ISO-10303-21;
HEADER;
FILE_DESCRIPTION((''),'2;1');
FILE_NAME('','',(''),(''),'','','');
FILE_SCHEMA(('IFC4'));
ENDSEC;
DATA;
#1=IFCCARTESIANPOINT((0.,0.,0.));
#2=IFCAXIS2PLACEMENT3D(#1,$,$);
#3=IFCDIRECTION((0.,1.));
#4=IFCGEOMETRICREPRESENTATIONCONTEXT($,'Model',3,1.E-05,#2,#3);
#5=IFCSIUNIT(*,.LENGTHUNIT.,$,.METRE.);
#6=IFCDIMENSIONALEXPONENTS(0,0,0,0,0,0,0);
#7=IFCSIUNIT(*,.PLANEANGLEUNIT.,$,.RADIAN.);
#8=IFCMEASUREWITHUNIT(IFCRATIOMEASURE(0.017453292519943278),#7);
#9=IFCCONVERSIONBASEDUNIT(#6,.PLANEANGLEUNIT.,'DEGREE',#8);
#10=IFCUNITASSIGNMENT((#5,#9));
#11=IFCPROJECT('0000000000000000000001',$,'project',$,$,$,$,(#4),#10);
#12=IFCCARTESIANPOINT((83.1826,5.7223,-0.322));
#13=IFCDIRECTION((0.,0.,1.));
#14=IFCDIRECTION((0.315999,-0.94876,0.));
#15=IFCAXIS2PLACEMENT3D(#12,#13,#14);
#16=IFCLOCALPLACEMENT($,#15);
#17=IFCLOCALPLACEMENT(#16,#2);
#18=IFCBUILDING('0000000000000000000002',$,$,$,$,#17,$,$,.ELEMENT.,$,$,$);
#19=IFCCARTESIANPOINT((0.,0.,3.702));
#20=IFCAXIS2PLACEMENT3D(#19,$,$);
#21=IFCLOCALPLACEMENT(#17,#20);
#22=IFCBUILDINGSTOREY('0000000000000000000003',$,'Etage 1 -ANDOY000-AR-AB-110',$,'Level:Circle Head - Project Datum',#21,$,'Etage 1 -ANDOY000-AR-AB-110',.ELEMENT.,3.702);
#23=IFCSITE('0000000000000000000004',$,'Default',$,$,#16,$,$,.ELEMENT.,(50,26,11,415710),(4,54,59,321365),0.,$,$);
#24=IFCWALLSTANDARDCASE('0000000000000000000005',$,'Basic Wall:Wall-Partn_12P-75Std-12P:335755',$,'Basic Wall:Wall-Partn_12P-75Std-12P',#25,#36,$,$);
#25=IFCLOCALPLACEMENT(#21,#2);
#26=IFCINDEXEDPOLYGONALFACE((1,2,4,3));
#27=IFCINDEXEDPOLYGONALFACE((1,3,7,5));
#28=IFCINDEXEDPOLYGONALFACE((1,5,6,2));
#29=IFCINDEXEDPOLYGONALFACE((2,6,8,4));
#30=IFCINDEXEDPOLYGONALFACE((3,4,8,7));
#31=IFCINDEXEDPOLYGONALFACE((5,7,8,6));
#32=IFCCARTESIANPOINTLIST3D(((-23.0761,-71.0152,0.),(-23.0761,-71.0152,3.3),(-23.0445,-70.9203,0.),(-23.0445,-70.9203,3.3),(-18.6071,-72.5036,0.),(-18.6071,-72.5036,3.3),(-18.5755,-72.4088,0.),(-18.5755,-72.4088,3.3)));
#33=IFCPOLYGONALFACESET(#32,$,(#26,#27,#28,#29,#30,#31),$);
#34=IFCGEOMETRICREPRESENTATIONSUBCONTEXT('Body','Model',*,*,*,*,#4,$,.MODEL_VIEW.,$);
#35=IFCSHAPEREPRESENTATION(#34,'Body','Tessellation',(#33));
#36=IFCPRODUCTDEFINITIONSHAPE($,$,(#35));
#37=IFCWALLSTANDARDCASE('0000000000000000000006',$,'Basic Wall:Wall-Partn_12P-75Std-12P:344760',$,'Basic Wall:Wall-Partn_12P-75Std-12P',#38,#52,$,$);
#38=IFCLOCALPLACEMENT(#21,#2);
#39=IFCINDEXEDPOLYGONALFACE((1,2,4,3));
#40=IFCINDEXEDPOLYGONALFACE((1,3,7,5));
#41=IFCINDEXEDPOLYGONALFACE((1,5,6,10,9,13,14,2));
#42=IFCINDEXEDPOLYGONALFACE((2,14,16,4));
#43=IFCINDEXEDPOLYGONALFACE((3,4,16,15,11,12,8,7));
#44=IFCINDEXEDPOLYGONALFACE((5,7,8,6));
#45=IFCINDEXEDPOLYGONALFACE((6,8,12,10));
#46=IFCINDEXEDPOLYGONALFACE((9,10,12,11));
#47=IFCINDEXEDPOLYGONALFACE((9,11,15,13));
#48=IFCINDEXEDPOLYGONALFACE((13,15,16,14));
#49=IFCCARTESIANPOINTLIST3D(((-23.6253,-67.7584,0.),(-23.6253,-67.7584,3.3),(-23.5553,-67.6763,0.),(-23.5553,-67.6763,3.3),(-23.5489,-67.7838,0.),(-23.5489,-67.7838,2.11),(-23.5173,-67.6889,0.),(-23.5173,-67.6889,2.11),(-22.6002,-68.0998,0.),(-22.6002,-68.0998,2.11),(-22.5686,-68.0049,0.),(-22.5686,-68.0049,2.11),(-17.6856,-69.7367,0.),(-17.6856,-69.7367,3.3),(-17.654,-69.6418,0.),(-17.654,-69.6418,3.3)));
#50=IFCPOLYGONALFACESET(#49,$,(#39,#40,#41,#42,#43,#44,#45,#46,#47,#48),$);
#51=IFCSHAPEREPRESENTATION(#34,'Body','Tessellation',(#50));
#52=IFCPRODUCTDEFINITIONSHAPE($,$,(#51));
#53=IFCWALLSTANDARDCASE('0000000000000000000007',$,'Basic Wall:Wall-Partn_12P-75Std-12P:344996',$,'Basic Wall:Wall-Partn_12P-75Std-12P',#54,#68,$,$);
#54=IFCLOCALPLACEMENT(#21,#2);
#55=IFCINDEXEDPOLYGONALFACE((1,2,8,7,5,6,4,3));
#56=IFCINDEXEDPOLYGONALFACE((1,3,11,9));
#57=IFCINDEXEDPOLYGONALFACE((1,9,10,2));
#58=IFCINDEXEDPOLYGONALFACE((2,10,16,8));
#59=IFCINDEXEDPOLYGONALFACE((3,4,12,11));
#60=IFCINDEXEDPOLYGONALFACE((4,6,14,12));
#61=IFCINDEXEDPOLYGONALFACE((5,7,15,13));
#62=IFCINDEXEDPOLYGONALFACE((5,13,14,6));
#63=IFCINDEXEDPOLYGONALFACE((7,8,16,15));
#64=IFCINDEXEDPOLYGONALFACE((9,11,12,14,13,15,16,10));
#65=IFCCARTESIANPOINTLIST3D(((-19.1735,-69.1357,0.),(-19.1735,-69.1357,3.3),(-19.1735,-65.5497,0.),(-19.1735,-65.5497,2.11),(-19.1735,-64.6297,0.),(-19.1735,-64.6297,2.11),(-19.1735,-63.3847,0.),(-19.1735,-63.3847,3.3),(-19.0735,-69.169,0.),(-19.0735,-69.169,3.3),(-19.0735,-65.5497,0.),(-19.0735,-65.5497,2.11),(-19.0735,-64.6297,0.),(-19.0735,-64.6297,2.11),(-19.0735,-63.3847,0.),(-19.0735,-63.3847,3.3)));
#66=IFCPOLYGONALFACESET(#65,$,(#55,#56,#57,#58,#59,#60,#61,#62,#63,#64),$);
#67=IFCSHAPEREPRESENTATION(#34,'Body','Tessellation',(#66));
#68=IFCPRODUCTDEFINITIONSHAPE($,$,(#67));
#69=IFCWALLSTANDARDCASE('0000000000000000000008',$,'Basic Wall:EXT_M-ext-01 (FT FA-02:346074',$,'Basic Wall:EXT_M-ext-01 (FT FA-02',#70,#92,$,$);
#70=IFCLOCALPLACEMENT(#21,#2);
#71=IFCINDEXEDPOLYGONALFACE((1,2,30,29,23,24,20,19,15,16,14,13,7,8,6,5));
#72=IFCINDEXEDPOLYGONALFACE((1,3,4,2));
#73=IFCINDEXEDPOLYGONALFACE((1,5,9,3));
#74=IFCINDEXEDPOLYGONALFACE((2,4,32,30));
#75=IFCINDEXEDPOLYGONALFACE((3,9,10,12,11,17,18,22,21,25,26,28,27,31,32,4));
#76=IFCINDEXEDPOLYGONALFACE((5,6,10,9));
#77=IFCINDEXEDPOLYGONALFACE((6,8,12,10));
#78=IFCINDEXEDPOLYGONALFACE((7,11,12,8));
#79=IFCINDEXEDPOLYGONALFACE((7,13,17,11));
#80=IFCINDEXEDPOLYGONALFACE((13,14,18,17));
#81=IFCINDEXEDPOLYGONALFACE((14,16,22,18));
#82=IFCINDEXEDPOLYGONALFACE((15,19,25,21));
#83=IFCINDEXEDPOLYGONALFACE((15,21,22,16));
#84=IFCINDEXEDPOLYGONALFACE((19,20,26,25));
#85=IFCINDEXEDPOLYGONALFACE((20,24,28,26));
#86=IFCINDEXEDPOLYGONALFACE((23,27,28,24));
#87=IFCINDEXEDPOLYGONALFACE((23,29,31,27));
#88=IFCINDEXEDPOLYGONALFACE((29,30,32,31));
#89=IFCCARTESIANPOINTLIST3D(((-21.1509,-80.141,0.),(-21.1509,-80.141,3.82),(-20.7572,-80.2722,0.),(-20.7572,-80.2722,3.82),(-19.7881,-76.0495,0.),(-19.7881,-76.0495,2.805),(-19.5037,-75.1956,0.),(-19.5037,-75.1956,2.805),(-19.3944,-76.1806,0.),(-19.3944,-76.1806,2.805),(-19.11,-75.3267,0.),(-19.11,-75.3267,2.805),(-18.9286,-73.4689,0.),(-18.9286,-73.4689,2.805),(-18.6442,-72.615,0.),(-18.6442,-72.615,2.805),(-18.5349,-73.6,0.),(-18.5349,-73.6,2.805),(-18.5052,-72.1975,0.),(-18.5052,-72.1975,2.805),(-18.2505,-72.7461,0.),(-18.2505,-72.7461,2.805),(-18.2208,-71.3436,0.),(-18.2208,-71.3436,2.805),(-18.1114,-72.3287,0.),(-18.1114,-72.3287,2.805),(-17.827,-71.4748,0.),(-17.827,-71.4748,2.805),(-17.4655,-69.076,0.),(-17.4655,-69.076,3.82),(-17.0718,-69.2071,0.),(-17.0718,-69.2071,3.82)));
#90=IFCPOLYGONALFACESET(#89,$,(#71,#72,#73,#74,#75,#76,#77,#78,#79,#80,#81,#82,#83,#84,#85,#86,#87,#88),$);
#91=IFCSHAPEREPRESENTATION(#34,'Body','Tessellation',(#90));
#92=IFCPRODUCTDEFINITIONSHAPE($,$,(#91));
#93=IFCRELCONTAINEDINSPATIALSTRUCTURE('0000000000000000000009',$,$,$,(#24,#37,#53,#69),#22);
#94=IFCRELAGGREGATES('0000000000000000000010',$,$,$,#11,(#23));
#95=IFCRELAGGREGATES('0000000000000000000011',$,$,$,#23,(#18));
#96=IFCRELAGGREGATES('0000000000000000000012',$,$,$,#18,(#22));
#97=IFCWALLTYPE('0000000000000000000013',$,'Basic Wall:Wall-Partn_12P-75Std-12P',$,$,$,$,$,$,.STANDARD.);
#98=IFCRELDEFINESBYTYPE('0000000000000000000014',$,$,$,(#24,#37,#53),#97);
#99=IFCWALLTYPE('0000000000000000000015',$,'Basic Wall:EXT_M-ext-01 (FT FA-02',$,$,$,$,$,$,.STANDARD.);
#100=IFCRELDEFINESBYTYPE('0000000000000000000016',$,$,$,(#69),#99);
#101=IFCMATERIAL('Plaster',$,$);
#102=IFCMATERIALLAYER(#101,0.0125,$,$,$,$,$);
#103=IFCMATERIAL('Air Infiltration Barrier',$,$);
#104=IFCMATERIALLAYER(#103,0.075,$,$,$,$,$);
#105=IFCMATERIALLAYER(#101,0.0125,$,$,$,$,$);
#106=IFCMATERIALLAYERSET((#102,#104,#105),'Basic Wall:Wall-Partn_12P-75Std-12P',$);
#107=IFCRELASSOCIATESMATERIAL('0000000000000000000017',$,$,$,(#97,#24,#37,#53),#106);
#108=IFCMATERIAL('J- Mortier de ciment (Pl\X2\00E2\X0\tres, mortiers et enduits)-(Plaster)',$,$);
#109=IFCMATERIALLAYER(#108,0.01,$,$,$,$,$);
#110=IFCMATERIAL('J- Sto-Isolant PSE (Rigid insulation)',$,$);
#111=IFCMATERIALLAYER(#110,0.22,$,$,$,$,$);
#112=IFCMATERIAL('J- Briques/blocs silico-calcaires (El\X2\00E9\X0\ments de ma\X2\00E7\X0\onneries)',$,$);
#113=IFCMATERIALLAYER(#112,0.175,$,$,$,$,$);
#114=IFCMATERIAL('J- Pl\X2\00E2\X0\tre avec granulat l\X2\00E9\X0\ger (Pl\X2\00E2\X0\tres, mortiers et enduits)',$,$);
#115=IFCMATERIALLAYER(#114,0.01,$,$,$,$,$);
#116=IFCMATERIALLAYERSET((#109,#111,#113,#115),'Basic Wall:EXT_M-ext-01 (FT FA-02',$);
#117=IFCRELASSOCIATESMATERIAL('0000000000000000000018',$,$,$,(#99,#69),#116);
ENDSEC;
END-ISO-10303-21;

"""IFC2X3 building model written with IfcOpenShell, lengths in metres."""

from ifc_helpers import new_model, entity, si_unit, converted_unit, direction, frame, frame_2d, origin, place, context, subcontext, project, spatial, polyline, rectangle, outline, extrude, material, layer, layer_set, layer_usage, type_object, element, save


model = new_model("IFC2X3")

# Units and contexts
model_context = context("Model", 3, precision=1e-05, world=origin(), true_north=direction((0.0, 1.0)))
body_context = subcontext(model_context, "Body", "Model", "MODEL_VIEW")
ifc_project = project(units=[si_unit("LENGTHUNIT", "METRE"), converted_unit("PLANEANGLEUNIT", "DEGREE", entity("IfcRatioMeasure", 0.017453292519943278), si_unit("PLANEANGLEUNIT", "RADIAN"), dimensions=[0, 0, 0, 0, 0, 0, 0])], contexts=[model_context])

# Site, building, storey
site_placement = place(None, frame((83.1826, 5.7223, -0.322), z_axis=(0.0, 0.0, 1.0), x_axis=(0.315999, -0.94876, 0.0)))
site = spatial("IfcSite", under=ifc_project, at=site_placement, Name="Default", CompositionType="ELEMENT", RefLatitude=(50, 26, 11, 415710), RefLongitude=(4, 54, 59, 321365), RefElevation=0.0)
building_placement = place(site_placement, origin())
building = spatial("IfcBuilding", under=site, at=building_placement, CompositionType="ELEMENT")
storey_placement = place(building_placement, frame((0.0, 0.0, 3.702)))
storey = spatial("IfcBuildingStorey", under=building, at=storey_placement, Name="Etage 1 -ANDOY000-AR-AB-110", ObjectType="Level:Circle Head - Project Datum", LongName="Etage 1 -ANDOY000-AR-AB-110", CompositionType="ELEMENT", Elevation=3.702)

# Wall
ifc_material_1 = material(Name="Plaster")
ifc_layer_1 = layer(ifc_material_1, 0.0125)
ifc_material_2 = material(Name="Air Infiltration Barrier")
ifc_layer_2 = layer(ifc_material_2, 0.075)
ifc_layer_3 = layer(ifc_material_1, 0.0125)
ifc_layer_set_1 = layer_set([ifc_layer_1, ifc_layer_2, ifc_layer_3], Name="Basic Wall:Wall-Partn_12P-75Std-12P")
ifc_layer_usage_1 = layer_usage(ifc_layer_set_1, "AXIS2", "NEGATIVE", 0.05)
wall_type_1 = type_object("IfcWallType", Name="Basic Wall:Wall-Partn_12P-75Std-12P", PredefinedType="STANDARD", material=ifc_layer_set_1)
wall_1_placement = place(storey_placement, frame((-18.5913, -72.4562, 0.0), z_axis=(0.0, 0.0, 1.0), x_axis=(-0.948759, 0.316, 0.0)))
element("IfcWallStandardCase", 1, at=wall_1_placement, inside=storey, type_object=wall_type_1, material=ifc_layer_usage_1, Name="Basic Wall:Wall-Partn_12P-75Std-12P:335755", ObjectType="Basic Wall:Wall-Partn_12P-75Std-12P", context=body_context, shape_type="SweptSolid", body=[
    extrude(rectangle(XDim=4.7103, YDim=0.1, at=frame_2d((2.3552, 0.0), x_axis=(-1.0, 0.0))), origin(), (0.0, 0.0, 1.0), 3.3),
])

# Walls, openings
wall_2_placement = place(storey_placement, frame((-17.6698, -69.6893, 0.0), z_axis=(0.0, 0.0, 1.0), x_axis=(-0.948759, 0.316, 0.0)))
wall_2 = element("IfcWallStandardCase", 2, at=wall_2_placement, inside=storey, type_object=wall_type_1, material=ifc_layer_usage_1, Name="Basic Wall:Wall-Partn_12P-75Std-12P:344760", ObjectType="Basic Wall:Wall-Partn_12P-75Std-12P", context=body_context, shape_type="SweptSolid", body=[
    extrude(outline(polyline([(0.0, -0.05), (1.4962, -0.05), (1.6016, -0.05), (6.2201, -0.05), (6.2605, 0.05), (0.0, 0.05), (0.0, -0.05)])), origin(), (0.0, 0.0, 1.0), 3.3),
])
opening_1_placement = place(wall_2_placement, frame((6.18, 0.05, 0.0)))
element("IfcOpeningElement", 3, at=opening_1_placement, cuts=wall_2, ObjectType="Opening", context=body_context, shape_type="SweptSolid", body=[
    extrude(rectangle(XDim=2.11, YDim=1.0, at=frame_2d((1.055, 0.5), x_axis=(1.0, 0.0))), frame((0.0, 0.0, 0.0), z_axis=(0.0, -1.0, 0.0), x_axis=(0.0, 0.0, 1.0)), (0.0, 0.0, 1.0), 0.1),
])
wall_3_placement = place(storey_placement, frame((-19.1235, -69.169, 0.0), z_axis=(0.0, 0.0, 1.0), x_axis=(0.0, 1.0, 0.0)))
wall_3 = element("IfcWallStandardCase", 4, at=wall_3_placement, inside=storey, type_object=wall_type_1, material=ifc_layer_usage_1, Name="Basic Wall:Wall-Partn_12P-75Std-12P:344996", ObjectType="Basic Wall:Wall-Partn_12P-75Std-12P", context=body_context, shape_type="SweptSolid", body=[
    extrude(outline(polyline([(0.0, -0.05), (4.7193, -0.05), (4.8193, -0.05), (5.7843, -0.05), (5.7843, 0.05), (0.0333, 0.05), (0.0, -0.05)])), origin(), (0.0, 0.0, 1.0), 3.3),
])
opening_2_placement = place(wall_3_placement, frame((4.5393, 0.05, 0.0)))
element("IfcOpeningElement", 5, at=opening_2_placement, cuts=wall_3, ObjectType="Opening", context=body_context, shape_type="SweptSolid", body=[
    extrude(rectangle(XDim=2.11, YDim=0.92, at=frame_2d((1.055, 0.46), x_axis=(1.0, 0.0))), frame((0.0, 0.0, 0.0), z_axis=(0.0, -1.0, 0.0), x_axis=(0.0, 0.0, 1.0)), (0.0, 0.0, 1.0), 0.1),
])

# Wall, openings
ifc_material_3 = material(Name="J- Mortier de ciment (Plâtres, mortiers et enduits)-(Plaster)")
ifc_layer_4 = layer(ifc_material_3, 0.01)
ifc_material_4 = material(Name="J- Sto-Isolant PSE (Rigid insulation)")
ifc_layer_5 = layer(ifc_material_4, 0.22)
ifc_material_5 = material(Name="J- Briques/blocs silico-calcaires (Eléments de maçonneries)")
ifc_layer_6 = layer(ifc_material_5, 0.175)
ifc_material_6 = material(Name="J- Plâtre avec granulat léger (Plâtres, mortiers et enduits)")
ifc_layer_7 = layer(ifc_material_6, 0.01)
ifc_layer_set_2 = layer_set([ifc_layer_4, ifc_layer_5, ifc_layer_6, ifc_layer_7], Name="Basic Wall:EXT_M-ext-01 (FT FA-02")
ifc_layer_usage_2 = layer_usage(ifc_layer_set_2, "AXIS2", "POSITIVE", -0.2075)
wall_type_2 = type_object("IfcWallType", Name="Basic Wall:EXT_M-ext-01 (FT FA-02", PredefinedType="STANDARD", material=ifc_layer_set_2)
wall_4_placement = place(storey_placement, frame((-20.954, -80.2066, 0.0), z_axis=(0.0, 0.0, 1.0), x_axis=(0.316, 0.948759, 0.0)))
wall_4 = element("IfcWallStandardCase", 6, at=wall_4_placement, inside=storey, type_object=wall_type_2, material=ifc_layer_usage_2, Name="Basic Wall:EXT_M-ext-01 (FT FA-02:346074", ObjectType="Basic Wall:EXT_M-ext-01 (FT FA-02", context=body_context, shape_type="SweptSolid", body=[
    extrude(rectangle(XDim=11.6626, YDim=0.415, at=frame_2d((5.8313, 0.0), x_axis=(-1.0, 0.0))), origin(), (0.0, 0.0, 1.0), 3.82),
])
opening_3_placement = place(wall_4_placement, frame((4.3125, -0.2075, 0.0)))
element("IfcOpeningElement", 7, at=opening_3_placement, cuts=wall_4, ObjectType="Opening", context=body_context, shape_type="SweptSolid", body=[
    extrude(rectangle(XDim=2.805, YDim=0.9, at=frame_2d((1.4025, 0.45), x_axis=(-1.0, 0.0))), frame((0.0, 0.0, 0.0), z_axis=(0.0, 1.0, 0.0), x_axis=(0.0, 0.0, 1.0)), (0.0, 0.0, 1.0), 0.415),
])
opening_4_placement = place(wall_4_placement, frame((7.0325, -0.2075, 0.0)))
element("IfcOpeningElement", 8, at=opening_4_placement, cuts=wall_4, ObjectType="Opening", context=body_context, shape_type="SweptSolid", body=[
    extrude(rectangle(XDim=2.805, YDim=0.9, at=frame_2d((1.4025, 0.45), x_axis=(-1.0, 0.0))), frame((0.0, 0.0, 0.0), z_axis=(0.0, 1.0, 0.0), x_axis=(0.0, 0.0, 1.0)), (0.0, 0.0, 1.0), 0.415),
])
opening_5_placement = place(wall_4_placement, frame((8.3725, -0.2075, 0.0)))
element("IfcOpeningElement", 9, at=opening_5_placement, cuts=wall_4, ObjectType="Opening", context=body_context, shape_type="SweptSolid", body=[
    extrude(rectangle(XDim=2.805, YDim=0.9, at=frame_2d((1.4025, 0.45), x_axis=(-1.0, 0.0))), frame((0.0, 0.0, 0.0), z_axis=(0.0, 1.0, 0.0), x_axis=(0.0, 0.0, 1.0)), (0.0, 0.0, 1.0), 0.415),
])

save(model, "model.ifc")
